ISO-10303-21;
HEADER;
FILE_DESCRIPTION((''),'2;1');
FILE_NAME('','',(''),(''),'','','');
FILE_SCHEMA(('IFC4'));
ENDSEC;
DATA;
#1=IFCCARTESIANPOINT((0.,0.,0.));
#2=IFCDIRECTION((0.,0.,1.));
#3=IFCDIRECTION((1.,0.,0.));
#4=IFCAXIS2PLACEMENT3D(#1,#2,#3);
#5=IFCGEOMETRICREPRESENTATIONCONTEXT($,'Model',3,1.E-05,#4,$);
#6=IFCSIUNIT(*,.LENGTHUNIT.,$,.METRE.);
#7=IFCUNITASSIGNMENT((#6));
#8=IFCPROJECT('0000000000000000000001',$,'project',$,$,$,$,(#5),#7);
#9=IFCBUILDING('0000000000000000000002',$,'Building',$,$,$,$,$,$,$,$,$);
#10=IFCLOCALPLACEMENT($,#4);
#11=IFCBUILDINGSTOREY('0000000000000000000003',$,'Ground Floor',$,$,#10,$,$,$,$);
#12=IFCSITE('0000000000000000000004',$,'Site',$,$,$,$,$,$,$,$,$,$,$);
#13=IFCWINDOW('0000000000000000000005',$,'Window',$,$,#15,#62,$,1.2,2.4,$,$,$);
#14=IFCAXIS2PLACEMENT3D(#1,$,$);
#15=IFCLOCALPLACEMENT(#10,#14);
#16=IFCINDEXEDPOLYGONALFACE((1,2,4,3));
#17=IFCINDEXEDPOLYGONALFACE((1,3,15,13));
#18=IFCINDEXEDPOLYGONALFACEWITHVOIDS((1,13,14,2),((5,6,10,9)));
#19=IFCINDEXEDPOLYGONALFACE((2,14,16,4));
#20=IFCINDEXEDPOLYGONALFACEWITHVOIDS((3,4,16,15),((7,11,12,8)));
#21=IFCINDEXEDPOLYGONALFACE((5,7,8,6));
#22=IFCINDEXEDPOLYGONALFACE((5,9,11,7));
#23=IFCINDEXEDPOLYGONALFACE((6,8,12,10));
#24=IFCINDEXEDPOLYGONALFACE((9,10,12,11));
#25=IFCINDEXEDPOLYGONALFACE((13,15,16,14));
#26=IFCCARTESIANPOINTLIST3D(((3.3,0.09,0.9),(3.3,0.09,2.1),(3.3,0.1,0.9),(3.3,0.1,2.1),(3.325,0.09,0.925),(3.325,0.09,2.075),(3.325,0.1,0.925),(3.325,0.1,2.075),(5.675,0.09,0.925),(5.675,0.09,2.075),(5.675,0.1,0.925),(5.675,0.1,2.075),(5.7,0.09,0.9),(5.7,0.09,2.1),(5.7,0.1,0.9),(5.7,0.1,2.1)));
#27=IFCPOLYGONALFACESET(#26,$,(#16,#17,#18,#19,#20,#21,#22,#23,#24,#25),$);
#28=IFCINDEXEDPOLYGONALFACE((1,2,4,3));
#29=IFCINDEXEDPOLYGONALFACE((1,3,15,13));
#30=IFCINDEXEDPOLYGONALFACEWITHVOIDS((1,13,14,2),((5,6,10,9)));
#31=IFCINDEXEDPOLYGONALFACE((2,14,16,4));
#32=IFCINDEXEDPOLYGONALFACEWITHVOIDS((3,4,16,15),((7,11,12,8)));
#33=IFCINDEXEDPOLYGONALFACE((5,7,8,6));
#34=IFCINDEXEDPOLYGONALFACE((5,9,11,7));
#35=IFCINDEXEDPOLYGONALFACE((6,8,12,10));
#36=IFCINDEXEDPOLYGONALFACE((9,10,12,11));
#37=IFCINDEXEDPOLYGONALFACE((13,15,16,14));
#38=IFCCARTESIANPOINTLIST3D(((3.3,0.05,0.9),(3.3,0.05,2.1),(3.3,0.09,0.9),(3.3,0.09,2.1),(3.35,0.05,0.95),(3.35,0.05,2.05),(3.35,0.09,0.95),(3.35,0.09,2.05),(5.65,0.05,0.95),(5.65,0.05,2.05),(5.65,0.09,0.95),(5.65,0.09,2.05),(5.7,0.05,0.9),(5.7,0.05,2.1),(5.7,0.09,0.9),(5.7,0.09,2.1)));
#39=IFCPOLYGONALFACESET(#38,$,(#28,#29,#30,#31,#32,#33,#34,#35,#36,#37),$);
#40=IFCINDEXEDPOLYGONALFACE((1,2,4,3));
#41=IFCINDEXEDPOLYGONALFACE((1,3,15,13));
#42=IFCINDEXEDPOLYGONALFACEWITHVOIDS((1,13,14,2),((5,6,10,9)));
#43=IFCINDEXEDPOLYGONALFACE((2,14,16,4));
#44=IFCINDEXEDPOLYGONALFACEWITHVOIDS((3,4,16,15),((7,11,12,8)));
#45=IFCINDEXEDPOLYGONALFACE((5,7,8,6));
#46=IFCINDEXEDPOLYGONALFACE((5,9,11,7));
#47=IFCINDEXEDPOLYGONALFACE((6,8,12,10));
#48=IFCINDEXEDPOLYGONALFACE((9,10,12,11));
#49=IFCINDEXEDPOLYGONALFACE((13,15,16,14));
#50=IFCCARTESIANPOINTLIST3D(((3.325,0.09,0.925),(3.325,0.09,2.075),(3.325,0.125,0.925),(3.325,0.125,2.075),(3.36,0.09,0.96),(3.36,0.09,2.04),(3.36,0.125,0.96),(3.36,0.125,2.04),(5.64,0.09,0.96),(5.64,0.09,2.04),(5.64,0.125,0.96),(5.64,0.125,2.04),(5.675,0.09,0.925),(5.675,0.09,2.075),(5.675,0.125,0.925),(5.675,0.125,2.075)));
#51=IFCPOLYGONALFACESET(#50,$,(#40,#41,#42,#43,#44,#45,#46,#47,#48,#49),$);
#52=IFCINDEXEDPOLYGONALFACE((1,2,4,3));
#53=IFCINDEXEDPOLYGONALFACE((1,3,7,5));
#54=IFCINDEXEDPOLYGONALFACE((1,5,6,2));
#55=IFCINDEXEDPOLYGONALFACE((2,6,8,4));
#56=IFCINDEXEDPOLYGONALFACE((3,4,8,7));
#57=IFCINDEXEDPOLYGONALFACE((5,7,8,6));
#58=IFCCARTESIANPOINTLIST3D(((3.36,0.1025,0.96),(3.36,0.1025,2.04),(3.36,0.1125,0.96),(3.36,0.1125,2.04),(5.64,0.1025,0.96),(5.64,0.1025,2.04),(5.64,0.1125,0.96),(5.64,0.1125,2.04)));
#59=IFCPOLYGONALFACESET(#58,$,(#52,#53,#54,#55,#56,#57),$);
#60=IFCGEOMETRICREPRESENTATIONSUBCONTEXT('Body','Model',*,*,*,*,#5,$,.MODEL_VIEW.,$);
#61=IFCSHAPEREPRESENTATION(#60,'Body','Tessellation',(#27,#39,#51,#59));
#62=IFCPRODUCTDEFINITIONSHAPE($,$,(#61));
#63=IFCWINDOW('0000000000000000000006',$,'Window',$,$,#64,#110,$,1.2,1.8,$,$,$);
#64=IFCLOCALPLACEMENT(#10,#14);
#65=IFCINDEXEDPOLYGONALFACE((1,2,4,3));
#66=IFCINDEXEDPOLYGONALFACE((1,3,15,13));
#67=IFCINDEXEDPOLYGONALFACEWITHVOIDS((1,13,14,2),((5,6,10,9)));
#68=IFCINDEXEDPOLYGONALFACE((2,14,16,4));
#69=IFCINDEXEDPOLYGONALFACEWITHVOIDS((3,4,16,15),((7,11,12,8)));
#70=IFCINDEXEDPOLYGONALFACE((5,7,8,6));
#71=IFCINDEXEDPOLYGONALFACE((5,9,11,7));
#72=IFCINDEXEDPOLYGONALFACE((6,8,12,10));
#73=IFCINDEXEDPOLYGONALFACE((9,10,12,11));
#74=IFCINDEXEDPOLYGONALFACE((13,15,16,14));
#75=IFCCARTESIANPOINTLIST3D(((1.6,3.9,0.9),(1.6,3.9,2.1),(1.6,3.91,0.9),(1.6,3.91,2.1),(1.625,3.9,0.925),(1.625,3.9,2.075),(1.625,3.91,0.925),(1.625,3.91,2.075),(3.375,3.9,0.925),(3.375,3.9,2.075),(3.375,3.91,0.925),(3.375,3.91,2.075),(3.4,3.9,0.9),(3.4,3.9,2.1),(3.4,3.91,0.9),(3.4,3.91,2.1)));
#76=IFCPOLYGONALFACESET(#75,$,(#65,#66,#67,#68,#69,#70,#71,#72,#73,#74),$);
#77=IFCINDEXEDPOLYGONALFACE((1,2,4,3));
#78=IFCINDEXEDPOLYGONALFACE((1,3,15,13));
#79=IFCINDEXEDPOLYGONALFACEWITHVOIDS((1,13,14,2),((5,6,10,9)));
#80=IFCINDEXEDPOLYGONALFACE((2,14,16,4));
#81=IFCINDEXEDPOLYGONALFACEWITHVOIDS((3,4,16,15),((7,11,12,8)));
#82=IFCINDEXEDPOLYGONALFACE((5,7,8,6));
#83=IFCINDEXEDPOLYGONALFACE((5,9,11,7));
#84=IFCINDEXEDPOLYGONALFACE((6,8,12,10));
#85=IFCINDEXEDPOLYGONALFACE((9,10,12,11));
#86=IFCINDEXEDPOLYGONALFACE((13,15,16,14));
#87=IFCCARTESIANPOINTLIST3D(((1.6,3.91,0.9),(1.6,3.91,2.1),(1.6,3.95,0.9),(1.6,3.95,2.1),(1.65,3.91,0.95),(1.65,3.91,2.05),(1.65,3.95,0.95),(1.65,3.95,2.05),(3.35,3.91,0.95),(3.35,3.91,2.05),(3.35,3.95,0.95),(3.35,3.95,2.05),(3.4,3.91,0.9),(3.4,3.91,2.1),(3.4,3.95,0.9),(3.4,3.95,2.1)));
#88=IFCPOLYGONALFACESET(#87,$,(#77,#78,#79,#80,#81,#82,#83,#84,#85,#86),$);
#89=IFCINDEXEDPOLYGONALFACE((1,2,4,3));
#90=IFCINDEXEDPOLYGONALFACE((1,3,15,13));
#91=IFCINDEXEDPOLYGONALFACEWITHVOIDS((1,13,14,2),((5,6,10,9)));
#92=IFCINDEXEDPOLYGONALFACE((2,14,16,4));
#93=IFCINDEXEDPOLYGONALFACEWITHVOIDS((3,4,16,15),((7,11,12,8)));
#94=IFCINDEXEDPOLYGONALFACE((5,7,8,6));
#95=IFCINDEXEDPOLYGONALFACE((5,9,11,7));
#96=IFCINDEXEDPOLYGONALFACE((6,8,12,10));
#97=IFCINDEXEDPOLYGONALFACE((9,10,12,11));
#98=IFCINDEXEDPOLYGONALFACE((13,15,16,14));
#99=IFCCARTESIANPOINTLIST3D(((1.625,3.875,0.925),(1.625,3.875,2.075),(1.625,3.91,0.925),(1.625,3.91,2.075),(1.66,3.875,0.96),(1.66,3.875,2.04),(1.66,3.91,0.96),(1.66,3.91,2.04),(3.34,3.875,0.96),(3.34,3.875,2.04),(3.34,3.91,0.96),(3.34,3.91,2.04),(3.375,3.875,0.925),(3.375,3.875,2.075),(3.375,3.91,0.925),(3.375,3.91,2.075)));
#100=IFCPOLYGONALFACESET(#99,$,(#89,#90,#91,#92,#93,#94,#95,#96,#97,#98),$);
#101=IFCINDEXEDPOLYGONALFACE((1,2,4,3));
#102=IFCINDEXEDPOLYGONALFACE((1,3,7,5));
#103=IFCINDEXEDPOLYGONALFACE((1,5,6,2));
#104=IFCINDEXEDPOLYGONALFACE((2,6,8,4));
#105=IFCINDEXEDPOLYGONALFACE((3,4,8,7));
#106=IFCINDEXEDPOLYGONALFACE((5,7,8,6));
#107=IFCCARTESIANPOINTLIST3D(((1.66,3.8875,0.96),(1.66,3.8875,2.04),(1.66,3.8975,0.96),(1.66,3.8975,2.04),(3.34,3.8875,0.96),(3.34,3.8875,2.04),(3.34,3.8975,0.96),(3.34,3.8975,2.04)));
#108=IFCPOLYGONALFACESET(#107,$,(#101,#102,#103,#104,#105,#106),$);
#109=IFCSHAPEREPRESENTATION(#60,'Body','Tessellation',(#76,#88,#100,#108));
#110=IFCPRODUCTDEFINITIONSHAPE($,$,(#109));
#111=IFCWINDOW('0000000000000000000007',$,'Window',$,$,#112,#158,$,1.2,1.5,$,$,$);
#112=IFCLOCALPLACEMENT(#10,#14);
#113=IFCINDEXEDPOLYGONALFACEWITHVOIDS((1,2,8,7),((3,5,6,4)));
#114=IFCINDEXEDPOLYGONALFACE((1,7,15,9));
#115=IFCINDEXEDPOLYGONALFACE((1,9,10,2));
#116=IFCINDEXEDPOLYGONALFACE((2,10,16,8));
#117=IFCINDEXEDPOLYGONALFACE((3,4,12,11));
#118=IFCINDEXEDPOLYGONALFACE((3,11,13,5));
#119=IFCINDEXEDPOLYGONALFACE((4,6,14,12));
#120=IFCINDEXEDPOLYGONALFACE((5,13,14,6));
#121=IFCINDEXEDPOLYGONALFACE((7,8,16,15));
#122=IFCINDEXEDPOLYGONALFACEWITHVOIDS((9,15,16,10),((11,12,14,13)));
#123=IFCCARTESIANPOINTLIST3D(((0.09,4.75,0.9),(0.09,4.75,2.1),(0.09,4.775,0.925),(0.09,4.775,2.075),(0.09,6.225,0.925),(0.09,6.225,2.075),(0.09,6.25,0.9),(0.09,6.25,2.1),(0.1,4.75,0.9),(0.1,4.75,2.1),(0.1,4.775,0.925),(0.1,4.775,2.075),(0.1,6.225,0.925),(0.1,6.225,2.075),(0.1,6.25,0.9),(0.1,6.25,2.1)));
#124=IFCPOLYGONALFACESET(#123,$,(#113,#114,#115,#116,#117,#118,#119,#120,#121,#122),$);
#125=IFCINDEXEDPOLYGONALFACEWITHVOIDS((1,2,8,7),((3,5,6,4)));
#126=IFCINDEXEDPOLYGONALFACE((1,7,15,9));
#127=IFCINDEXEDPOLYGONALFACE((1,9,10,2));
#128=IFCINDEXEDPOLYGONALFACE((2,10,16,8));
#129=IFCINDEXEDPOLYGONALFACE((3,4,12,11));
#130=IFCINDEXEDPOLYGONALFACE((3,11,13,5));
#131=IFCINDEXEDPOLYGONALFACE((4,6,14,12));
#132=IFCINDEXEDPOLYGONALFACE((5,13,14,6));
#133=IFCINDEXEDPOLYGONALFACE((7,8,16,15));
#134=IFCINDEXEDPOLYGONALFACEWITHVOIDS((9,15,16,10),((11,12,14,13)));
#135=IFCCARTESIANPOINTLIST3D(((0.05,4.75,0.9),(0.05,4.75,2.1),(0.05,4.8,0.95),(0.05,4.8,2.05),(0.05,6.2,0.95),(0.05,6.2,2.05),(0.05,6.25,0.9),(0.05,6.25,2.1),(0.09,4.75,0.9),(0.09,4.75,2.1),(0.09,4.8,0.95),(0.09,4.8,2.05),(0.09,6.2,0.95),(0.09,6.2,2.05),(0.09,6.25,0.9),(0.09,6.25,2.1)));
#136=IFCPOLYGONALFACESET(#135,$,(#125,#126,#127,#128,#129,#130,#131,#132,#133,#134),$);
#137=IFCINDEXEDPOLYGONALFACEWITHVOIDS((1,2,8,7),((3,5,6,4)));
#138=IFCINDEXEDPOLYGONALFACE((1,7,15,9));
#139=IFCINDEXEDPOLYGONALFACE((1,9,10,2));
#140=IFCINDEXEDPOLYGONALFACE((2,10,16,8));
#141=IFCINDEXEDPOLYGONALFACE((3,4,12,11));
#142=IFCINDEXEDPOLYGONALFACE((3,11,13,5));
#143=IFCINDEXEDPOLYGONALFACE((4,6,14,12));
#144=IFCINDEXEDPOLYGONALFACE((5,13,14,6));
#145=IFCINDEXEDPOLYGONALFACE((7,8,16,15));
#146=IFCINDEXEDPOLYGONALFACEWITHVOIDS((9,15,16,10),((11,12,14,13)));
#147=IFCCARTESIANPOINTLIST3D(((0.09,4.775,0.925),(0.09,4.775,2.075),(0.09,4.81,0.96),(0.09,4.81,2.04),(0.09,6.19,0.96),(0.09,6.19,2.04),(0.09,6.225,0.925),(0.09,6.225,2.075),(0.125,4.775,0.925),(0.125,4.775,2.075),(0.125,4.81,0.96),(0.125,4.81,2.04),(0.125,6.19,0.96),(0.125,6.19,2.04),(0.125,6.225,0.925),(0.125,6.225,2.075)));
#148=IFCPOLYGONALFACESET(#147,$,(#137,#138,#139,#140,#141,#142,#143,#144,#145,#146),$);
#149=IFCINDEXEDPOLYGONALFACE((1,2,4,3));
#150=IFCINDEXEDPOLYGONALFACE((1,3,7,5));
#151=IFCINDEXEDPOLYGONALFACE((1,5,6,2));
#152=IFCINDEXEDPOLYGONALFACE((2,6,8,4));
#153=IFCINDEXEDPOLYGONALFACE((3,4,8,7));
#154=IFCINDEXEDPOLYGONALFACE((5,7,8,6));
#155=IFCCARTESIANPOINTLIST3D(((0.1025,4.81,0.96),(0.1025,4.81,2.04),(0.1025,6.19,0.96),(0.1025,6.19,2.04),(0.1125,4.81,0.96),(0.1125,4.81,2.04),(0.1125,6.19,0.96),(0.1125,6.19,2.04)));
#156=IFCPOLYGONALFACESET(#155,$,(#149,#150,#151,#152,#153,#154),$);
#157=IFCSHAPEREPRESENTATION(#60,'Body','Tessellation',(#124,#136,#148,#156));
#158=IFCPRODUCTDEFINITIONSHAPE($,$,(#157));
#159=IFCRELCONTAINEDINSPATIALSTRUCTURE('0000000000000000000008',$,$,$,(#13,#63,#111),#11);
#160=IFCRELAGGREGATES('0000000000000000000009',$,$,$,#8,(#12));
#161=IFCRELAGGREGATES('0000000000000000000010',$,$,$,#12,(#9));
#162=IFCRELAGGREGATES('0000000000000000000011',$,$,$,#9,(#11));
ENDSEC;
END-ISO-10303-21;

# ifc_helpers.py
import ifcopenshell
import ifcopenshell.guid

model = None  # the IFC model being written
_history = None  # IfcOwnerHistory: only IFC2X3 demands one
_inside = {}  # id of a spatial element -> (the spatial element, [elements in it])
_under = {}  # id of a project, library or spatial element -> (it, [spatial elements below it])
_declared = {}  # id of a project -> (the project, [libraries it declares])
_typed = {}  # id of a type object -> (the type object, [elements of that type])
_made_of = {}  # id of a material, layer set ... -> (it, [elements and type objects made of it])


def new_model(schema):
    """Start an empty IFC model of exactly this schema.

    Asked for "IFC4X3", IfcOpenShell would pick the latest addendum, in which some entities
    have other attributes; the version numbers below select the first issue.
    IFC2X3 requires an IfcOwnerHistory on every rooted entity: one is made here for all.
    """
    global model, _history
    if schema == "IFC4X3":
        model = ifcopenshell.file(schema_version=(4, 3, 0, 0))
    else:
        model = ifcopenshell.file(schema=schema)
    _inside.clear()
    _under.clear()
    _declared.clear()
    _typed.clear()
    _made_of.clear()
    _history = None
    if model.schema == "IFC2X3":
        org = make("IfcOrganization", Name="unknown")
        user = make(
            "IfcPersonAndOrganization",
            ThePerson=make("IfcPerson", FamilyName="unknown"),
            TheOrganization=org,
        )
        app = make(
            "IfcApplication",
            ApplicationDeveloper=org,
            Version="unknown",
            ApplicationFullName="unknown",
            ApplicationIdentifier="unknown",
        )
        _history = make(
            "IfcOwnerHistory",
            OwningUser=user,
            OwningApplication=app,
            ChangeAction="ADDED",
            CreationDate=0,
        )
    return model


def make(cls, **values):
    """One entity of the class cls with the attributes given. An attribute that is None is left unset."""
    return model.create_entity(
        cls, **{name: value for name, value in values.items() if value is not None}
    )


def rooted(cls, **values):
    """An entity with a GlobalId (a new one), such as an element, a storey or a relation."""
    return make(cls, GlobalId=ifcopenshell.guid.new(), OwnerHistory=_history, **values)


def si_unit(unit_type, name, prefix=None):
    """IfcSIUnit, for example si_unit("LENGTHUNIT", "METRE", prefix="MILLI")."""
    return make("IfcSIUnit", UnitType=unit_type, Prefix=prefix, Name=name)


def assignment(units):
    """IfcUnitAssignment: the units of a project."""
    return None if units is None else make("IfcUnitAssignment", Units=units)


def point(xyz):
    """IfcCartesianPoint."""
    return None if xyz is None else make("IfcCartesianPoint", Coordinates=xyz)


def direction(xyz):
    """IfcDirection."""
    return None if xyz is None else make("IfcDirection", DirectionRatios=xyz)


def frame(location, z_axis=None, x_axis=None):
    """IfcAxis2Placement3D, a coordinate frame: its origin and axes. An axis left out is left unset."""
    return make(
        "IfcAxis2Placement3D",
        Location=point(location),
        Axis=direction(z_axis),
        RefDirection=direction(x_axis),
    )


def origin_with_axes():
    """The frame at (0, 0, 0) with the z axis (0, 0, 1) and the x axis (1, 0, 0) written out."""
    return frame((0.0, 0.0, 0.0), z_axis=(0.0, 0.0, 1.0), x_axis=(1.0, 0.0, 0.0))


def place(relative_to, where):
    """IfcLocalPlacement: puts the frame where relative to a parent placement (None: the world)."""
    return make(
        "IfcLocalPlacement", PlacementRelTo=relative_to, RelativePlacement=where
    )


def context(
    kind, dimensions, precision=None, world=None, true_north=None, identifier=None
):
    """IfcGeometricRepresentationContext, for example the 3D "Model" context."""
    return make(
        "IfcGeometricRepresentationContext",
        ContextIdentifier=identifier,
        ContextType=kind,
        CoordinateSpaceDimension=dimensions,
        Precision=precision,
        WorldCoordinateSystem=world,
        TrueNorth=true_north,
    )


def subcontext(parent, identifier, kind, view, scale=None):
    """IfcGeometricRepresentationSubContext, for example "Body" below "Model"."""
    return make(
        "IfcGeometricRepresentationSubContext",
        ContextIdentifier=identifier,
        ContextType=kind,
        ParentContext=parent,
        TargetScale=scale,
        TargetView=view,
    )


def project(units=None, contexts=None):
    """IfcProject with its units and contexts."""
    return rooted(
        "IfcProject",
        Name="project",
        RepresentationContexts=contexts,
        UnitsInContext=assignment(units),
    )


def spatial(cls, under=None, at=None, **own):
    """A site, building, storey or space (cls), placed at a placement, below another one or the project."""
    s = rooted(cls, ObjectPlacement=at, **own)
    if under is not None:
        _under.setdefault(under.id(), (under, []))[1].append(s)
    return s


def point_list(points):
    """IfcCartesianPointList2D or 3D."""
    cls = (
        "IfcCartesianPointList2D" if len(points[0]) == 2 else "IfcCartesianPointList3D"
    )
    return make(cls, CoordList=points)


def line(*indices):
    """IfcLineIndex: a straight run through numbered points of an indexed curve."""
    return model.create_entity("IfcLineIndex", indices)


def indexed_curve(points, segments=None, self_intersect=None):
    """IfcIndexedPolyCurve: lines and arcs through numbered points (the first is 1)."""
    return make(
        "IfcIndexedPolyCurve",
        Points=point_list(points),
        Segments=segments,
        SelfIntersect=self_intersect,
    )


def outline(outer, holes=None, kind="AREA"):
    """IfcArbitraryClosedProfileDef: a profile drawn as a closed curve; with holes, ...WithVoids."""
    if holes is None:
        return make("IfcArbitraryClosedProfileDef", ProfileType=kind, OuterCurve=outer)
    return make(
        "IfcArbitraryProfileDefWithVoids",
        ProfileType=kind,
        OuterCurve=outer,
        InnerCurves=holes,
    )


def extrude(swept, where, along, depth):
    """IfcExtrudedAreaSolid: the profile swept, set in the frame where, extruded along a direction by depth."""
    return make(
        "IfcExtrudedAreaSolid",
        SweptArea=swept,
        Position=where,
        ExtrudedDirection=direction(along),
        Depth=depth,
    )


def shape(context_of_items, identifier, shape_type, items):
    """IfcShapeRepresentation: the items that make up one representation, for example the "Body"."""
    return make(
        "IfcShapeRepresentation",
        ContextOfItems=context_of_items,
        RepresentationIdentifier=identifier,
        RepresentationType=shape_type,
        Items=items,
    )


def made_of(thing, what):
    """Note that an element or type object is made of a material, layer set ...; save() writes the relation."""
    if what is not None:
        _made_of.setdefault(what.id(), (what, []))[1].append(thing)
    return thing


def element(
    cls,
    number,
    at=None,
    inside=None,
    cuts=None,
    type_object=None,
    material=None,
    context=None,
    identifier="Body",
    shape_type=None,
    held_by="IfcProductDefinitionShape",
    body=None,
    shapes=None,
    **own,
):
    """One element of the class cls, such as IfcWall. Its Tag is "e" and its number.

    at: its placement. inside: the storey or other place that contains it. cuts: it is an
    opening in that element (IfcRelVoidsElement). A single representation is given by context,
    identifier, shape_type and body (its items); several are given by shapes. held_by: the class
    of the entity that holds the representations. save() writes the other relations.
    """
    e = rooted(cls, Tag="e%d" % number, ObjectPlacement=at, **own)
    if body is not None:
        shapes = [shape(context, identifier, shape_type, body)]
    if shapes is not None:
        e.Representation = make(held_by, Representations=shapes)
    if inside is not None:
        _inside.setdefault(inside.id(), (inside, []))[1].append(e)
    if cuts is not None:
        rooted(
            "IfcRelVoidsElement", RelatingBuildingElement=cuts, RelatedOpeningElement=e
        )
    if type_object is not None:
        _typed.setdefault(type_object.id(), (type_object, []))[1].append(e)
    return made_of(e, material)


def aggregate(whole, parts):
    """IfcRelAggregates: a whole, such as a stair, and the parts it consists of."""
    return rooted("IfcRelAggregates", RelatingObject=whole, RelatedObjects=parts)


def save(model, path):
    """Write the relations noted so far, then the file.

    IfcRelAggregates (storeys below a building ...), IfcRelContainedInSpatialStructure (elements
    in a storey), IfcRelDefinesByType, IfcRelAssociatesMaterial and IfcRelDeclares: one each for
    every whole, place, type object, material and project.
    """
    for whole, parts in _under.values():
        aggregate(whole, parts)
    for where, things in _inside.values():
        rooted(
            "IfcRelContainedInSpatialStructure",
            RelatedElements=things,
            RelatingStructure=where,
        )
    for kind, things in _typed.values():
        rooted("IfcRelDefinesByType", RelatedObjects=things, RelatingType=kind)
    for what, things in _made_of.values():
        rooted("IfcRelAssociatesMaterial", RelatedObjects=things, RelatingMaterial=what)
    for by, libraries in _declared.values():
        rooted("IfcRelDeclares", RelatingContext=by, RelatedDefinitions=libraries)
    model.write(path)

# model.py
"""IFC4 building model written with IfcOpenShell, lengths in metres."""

from ifc_helpers import new_model, si_unit, frame, origin_with_axes, place, context, subcontext, project, spatial, line, indexed_curve, outline, extrude, element, save


model = new_model("IFC4")

# Units and contexts
model_context = context("Model", 3, precision=1e-05, world=origin_with_axes())
body_context = subcontext(model_context, "Body", "Model", "MODEL_VIEW")
ifc_project = project(units=[si_unit("LENGTHUNIT", "METRE")], contexts=[model_context])

# Site, building, storey
site = spatial("IfcSite", under=ifc_project, Name="Site")
building = spatial("IfcBuilding", under=site, Name="Building")
storey_placement = place(None, origin_with_axes())
storey = spatial("IfcBuildingStorey", under=building, at=storey_placement, Name="Ground Floor")

# Windows
window_1_placement = place(storey_placement, frame((3.3, 0.0, 0.9), z_axis=(0.0, 0.0, 1.0), x_axis=(1.0, 0.0, 0.0)))
element("IfcWindow", 1, at=window_1_placement, inside=storey, Name="Window", OverallHeight=1.2, OverallWidth=2.4, context=body_context, shape_type="SweptSolid", body=[
    extrude(outline(indexed_curve([(0.0, 0.0), (2.4, 0.0), (2.4, 1.2), (0.0, 1.2)], segments=[line(1, 2, 3, 4, 1)]), holes=[indexed_curve([(0.025, 0.025), (2.375, 0.025), (2.375, 1.175), (0.025, 1.175)], segments=[line(1, 2, 3, 4, 1)])]), frame((0.0, 0.09, 0.0), z_axis=(0.0, -1.0, 0.0), x_axis=(1.0, 0.0, 0.0)), (0.0, 0.0, -1.0), 0.01),
    extrude(outline(indexed_curve([(0.0, 0.0), (2.4, 0.0), (2.4, 1.2), (0.0, 1.2)], segments=[line(1, 2, 3, 4, 1)]), holes=[indexed_curve([(0.05, 0.05), (2.35, 0.05), (2.35, 1.15), (0.05, 1.15)], segments=[line(1, 2, 3, 4, 1)])]), frame((0.0, 0.05, 0.0), z_axis=(0.0, -1.0, 0.0), x_axis=(1.0, 0.0, 0.0)), (0.0, 0.0, -1.0), 0.04),
    extrude(outline(indexed_curve([(0.0, 0.0), (2.35, 0.0), (2.35, 1.15), (0.0, 1.15)], segments=[line(1, 2, 3, 4, 1)]), holes=[indexed_curve([(0.035, 0.035), (2.315, 0.035), (2.315, 1.115), (0.035, 1.115)], segments=[line(1, 2, 3, 4, 1)])]), frame((0.025, 0.09, 0.025), z_axis=(0.0, -1.0, 0.0), x_axis=(1.0, 0.0, 0.0)), (0.0, 0.0, -1.0), 0.035),
    extrude(outline(indexed_curve([(0.035, 0.035), (2.315, 0.035), (2.315, 1.115), (0.035, 1.115)], segments=[line(1, 2, 3, 4, 1)])), frame((0.025, 0.1025, 0.025), z_axis=(0.0, -1.0, 0.0), x_axis=(1.0, 0.0, 0.0)), (0.0, 0.0, -1.0), 0.01),
])
window_2_placement = place(storey_placement, frame((3.4, 4.0, 0.9), z_axis=(0.0, 0.0, 1.0), x_axis=(-1.0, 0.0, 0.0)))
element("IfcWindow", 2, at=window_2_placement, inside=storey, Name="Window", OverallHeight=1.2, OverallWidth=1.8, context=body_context, shape_type="SweptSolid", body=[
    extrude(outline(indexed_curve([(0.0, 0.0), (1.8, 0.0), (1.8, 1.2), (0.0, 1.2)], segments=[line(1, 2, 3, 4, 1)]), holes=[indexed_curve([(0.025, 0.025), (1.775, 0.025), (1.775, 1.175), (0.025, 1.175)], segments=[line(1, 2, 3, 4, 1)])]), frame((0.0, 0.09, 0.0), z_axis=(0.0, -1.0, 0.0), x_axis=(1.0, 0.0, 0.0)), (0.0, 0.0, -1.0), 0.01),
    extrude(outline(indexed_curve([(0.0, 0.0), (1.8, 0.0), (1.8, 1.2), (0.0, 1.2)], segments=[line(1, 2, 3, 4, 1)]), holes=[indexed_curve([(0.05, 0.05), (1.75, 0.05), (1.75, 1.15), (0.05, 1.15)], segments=[line(1, 2, 3, 4, 1)])]), frame((0.0, 0.05, 0.0), z_axis=(0.0, -1.0, 0.0), x_axis=(1.0, 0.0, 0.0)), (0.0, 0.0, -1.0), 0.04),
    extrude(outline(indexed_curve([(0.0, 0.0), (1.75, 0.0), (1.75, 1.15), (0.0, 1.15)], segments=[line(1, 2, 3, 4, 1)]), holes=[indexed_curve([(0.035, 0.035), (1.715, 0.035), (1.715, 1.115), (0.035, 1.115)], segments=[line(1, 2, 3, 4, 1)])]), frame((0.025, 0.09, 0.025), z_axis=(0.0, -1.0, 0.0), x_axis=(1.0, 0.0, 0.0)), (0.0, 0.0, -1.0), 0.035),
    extrude(outline(indexed_curve([(0.035, 0.035), (1.715, 0.035), (1.715, 1.115), (0.035, 1.115)], segments=[line(1, 2, 3, 4, 1)])), frame((0.025, 0.1025, 0.025), z_axis=(0.0, -1.0, 0.0), x_axis=(1.0, 0.0, 0.0)), (0.0, 0.0, -1.0), 0.01),
])
window_3_placement = place(storey_placement, frame((0.0, 6.25, 0.9), z_axis=(0.0, 0.0, 1.0), x_axis=(0.0, -1.0, 0.0)))
element("IfcWindow", 3, at=window_3_placement, inside=storey, Name="Window", OverallHeight=1.2, OverallWidth=1.5, context=body_context, shape_type="SweptSolid", body=[
    extrude(outline(indexed_curve([(0.0, 0.0), (1.5, 0.0), (1.5, 1.2), (0.0, 1.2)], segments=[line(1, 2, 3, 4, 1)]), holes=[indexed_curve([(0.025, 0.025), (1.475, 0.025), (1.475, 1.175), (0.025, 1.175)], segments=[line(1, 2, 3, 4, 1)])]), frame((0.0, 0.09, 0.0), z_axis=(0.0, -1.0, 0.0), x_axis=(1.0, 0.0, 0.0)), (0.0, 0.0, -1.0), 0.01),
    extrude(outline(indexed_curve([(0.0, 0.0), (1.5, 0.0), (1.5, 1.2), (0.0, 1.2)], segments=[line(1, 2, 3, 4, 1)]), holes=[indexed_curve([(0.05, 0.05), (1.45, 0.05), (1.45, 1.15), (0.05, 1.15)], segments=[line(1, 2, 3, 4, 1)])]), frame((0.0, 0.05, 0.0), z_axis=(0.0, -1.0, 0.0), x_axis=(1.0, 0.0, 0.0)), (0.0, 0.0, -1.0), 0.04),
    extrude(outline(indexed_curve([(0.0, 0.0), (1.45, 0.0), (1.45, 1.15), (0.0, 1.15)], segments=[line(1, 2, 3, 4, 1)]), holes=[indexed_curve([(0.035, 0.035), (1.415, 0.035), (1.415, 1.115), (0.035, 1.115)], segments=[line(1, 2, 3, 4, 1)])]), frame((0.025, 0.09, 0.025), z_axis=(0.0, -1.0, 0.0), x_axis=(1.0, 0.0, 0.0)), (0.0, 0.0, -1.0), 0.035),
    extrude(outline(indexed_curve([(0.035, 0.035), (1.415, 0.035), (1.415, 1.115), (0.035, 1.115)], segments=[line(1, 2, 3, 4, 1)])), frame((0.025, 0.1025, 0.025), z_axis=(0.0, -1.0, 0.0), x_axis=(1.0, 0.0, 0.0)), (0.0, 0.0, -1.0), 0.01),
])

save(model, "model.ifc")
